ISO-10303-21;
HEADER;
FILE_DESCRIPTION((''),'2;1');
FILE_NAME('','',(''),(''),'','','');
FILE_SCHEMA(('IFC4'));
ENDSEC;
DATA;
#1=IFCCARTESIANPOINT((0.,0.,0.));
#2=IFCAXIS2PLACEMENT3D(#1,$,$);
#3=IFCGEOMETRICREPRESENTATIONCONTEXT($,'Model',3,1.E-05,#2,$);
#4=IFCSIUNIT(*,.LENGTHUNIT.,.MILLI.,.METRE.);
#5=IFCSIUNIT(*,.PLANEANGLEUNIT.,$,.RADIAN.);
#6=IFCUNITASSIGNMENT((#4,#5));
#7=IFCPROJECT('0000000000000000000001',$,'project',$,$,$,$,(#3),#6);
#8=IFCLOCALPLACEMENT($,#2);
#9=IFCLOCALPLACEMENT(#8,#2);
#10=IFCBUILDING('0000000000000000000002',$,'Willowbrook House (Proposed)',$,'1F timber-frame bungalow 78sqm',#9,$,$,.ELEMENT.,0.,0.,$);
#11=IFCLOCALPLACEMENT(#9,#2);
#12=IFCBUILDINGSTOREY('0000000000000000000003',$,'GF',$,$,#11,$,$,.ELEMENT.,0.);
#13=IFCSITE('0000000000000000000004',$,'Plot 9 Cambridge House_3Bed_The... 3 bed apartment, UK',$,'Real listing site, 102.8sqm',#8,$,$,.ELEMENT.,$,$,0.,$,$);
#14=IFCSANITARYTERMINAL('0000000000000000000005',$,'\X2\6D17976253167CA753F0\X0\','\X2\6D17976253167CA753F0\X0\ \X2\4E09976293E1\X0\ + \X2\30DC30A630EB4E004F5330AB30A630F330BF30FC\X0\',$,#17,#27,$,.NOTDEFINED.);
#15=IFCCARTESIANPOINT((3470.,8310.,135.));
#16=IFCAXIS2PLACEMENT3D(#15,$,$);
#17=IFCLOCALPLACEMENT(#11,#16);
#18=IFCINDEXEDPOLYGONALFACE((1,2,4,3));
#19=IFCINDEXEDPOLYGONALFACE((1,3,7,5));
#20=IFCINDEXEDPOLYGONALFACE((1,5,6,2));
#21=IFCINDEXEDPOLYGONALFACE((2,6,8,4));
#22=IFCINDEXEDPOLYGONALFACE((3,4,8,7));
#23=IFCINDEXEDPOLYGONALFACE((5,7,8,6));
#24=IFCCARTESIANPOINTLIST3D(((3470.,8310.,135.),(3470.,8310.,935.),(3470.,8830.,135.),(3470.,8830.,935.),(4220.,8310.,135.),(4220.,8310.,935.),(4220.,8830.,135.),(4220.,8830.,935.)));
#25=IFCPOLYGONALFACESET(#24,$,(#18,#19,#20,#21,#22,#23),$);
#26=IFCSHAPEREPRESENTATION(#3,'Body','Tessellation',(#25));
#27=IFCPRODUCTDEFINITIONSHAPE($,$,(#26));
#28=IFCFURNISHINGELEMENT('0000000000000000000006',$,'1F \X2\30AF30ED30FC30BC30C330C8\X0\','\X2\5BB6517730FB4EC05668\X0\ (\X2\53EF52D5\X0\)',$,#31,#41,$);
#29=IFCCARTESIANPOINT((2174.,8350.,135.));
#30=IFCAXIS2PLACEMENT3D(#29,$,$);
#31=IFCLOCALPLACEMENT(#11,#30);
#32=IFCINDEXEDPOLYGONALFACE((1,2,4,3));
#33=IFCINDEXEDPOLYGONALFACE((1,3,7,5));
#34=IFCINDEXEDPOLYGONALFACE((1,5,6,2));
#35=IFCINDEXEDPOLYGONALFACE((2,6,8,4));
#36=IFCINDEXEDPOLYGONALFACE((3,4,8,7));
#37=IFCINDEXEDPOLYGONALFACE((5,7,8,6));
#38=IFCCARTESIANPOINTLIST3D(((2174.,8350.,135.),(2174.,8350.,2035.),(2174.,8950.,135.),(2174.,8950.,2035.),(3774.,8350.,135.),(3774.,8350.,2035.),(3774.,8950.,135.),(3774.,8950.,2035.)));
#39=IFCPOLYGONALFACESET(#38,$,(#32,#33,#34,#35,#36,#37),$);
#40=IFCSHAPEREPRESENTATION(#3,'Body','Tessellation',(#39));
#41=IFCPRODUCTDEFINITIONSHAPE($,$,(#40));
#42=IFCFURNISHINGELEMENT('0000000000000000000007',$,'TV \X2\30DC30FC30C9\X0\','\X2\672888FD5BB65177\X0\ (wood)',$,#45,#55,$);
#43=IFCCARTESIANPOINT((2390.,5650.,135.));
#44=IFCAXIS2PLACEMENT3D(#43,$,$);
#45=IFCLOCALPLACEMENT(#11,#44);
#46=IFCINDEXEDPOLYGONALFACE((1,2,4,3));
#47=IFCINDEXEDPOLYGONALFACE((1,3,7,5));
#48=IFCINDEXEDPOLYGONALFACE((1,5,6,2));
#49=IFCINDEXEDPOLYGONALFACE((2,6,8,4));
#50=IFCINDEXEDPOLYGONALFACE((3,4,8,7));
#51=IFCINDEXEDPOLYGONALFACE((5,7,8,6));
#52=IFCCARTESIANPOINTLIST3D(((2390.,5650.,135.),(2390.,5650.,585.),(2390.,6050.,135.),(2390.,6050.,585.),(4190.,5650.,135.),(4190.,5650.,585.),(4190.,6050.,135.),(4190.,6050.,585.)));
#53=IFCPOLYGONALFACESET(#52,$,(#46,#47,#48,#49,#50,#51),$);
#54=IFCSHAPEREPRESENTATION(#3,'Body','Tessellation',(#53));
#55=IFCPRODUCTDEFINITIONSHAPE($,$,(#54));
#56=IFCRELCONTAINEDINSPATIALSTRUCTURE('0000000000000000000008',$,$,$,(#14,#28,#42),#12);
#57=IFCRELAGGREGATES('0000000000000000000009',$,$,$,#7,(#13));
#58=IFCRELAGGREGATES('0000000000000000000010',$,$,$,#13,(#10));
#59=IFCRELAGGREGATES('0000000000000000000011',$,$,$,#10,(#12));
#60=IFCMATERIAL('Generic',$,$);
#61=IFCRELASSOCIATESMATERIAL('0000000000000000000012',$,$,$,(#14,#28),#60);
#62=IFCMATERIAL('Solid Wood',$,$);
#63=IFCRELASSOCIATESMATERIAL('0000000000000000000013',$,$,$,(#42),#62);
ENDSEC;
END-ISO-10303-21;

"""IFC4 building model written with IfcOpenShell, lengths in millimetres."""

from ifc_helpers import new_model, si_unit, frame, frame_2d, origin, place, context, project, spatial, rectangle, extrude, material, element, save


model = new_model("IFC4")

# Units and contexts
model_context = context("Model", 3, precision=1e-05, world=origin())
ifc_project = project(units=[si_unit("LENGTHUNIT", "METRE", prefix="MILLI"), si_unit("PLANEANGLEUNIT", "RADIAN")], contexts=[model_context])

# Site, building, storey
site_placement = place(None, origin())
site = spatial("IfcSite", under=ifc_project, at=site_placement, Name="Plot 9 Cambridge House_3Bed_The... 3 bed apartment, UK", ObjectType="Real listing site, 102.8sqm", CompositionType="ELEMENT", RefElevation=0.0)
building_placement = place(site_placement, origin())
building = spatial("IfcBuilding", under=site, at=building_placement, Name="Willowbrook House (Proposed)", ObjectType="1F timber-frame bungalow 78sqm", CompositionType="ELEMENT", ElevationOfRefHeight=0.0, ElevationOfTerrain=0.0)
storey_placement = place(building_placement, origin())
storey = spatial("IfcBuildingStorey", under=building, at=storey_placement, Name="GF", CompositionType="ELEMENT", Elevation=0.0)

# Shared definitions
ifc_material_1 = material(Name="Solid Wood")

# Shared definitions
ifc_material_2 = material(Name="Generic")

# Sanitary terminal
sanitary_terminal_1_placement = place(storey_placement, frame((3470.0, 8310.0, 135.0)))
element("IfcSanitaryTerminal", 1, at=sanitary_terminal_1_placement, inside=storey, material=ifc_material_2, Name="洗面化粧台", Description="洗面化粧台 三面鏡 + ボウル一体カウンター", PredefinedType="NOTDEFINED", context=model_context, shape_type="SweptSolid", body=[
    extrude(rectangle(XDim=750.0, YDim=520.0, at=frame_2d((375.0, 260.0))), frame((3470.0, 8310.0, 135.0)), (0.0, 0.0, 1.0), 800.0),
])

# Furnishing elements
furnishing_1_placement = place(storey_placement, frame((2174.0, 8350.0, 135.0)))
element("IfcFurnishingElement", 2, at=furnishing_1_placement, inside=storey, material=ifc_material_2, Name="1F クローゼット", Description="家具・什器 (可動)", context=model_context, shape_type="SweptSolid", body=[
    extrude(rectangle(XDim=1600.0, YDim=600.0, at=frame_2d((800.0, 300.0))), frame((2174.0, 8350.0, 135.0)), (0.0, 0.0, 1.0), 1900.0),
])
furnishing_2_placement = place(storey_placement, frame((2390.0, 5650.0, 135.0)))
element("IfcFurnishingElement", 3, at=furnishing_2_placement, inside=storey, material=ifc_material_1, Name="TV ボード", Description="木製家具 (wood)", context=model_context, shape_type="SweptSolid", body=[
    extrude(rectangle(XDim=1800.0, YDim=400.0, at=frame_2d((900.0, 200.0))), frame((2390.0, 5650.0, 135.0)), (0.0, 0.0, 1.0), 450.0),
])

save(model, "model.ifc")
